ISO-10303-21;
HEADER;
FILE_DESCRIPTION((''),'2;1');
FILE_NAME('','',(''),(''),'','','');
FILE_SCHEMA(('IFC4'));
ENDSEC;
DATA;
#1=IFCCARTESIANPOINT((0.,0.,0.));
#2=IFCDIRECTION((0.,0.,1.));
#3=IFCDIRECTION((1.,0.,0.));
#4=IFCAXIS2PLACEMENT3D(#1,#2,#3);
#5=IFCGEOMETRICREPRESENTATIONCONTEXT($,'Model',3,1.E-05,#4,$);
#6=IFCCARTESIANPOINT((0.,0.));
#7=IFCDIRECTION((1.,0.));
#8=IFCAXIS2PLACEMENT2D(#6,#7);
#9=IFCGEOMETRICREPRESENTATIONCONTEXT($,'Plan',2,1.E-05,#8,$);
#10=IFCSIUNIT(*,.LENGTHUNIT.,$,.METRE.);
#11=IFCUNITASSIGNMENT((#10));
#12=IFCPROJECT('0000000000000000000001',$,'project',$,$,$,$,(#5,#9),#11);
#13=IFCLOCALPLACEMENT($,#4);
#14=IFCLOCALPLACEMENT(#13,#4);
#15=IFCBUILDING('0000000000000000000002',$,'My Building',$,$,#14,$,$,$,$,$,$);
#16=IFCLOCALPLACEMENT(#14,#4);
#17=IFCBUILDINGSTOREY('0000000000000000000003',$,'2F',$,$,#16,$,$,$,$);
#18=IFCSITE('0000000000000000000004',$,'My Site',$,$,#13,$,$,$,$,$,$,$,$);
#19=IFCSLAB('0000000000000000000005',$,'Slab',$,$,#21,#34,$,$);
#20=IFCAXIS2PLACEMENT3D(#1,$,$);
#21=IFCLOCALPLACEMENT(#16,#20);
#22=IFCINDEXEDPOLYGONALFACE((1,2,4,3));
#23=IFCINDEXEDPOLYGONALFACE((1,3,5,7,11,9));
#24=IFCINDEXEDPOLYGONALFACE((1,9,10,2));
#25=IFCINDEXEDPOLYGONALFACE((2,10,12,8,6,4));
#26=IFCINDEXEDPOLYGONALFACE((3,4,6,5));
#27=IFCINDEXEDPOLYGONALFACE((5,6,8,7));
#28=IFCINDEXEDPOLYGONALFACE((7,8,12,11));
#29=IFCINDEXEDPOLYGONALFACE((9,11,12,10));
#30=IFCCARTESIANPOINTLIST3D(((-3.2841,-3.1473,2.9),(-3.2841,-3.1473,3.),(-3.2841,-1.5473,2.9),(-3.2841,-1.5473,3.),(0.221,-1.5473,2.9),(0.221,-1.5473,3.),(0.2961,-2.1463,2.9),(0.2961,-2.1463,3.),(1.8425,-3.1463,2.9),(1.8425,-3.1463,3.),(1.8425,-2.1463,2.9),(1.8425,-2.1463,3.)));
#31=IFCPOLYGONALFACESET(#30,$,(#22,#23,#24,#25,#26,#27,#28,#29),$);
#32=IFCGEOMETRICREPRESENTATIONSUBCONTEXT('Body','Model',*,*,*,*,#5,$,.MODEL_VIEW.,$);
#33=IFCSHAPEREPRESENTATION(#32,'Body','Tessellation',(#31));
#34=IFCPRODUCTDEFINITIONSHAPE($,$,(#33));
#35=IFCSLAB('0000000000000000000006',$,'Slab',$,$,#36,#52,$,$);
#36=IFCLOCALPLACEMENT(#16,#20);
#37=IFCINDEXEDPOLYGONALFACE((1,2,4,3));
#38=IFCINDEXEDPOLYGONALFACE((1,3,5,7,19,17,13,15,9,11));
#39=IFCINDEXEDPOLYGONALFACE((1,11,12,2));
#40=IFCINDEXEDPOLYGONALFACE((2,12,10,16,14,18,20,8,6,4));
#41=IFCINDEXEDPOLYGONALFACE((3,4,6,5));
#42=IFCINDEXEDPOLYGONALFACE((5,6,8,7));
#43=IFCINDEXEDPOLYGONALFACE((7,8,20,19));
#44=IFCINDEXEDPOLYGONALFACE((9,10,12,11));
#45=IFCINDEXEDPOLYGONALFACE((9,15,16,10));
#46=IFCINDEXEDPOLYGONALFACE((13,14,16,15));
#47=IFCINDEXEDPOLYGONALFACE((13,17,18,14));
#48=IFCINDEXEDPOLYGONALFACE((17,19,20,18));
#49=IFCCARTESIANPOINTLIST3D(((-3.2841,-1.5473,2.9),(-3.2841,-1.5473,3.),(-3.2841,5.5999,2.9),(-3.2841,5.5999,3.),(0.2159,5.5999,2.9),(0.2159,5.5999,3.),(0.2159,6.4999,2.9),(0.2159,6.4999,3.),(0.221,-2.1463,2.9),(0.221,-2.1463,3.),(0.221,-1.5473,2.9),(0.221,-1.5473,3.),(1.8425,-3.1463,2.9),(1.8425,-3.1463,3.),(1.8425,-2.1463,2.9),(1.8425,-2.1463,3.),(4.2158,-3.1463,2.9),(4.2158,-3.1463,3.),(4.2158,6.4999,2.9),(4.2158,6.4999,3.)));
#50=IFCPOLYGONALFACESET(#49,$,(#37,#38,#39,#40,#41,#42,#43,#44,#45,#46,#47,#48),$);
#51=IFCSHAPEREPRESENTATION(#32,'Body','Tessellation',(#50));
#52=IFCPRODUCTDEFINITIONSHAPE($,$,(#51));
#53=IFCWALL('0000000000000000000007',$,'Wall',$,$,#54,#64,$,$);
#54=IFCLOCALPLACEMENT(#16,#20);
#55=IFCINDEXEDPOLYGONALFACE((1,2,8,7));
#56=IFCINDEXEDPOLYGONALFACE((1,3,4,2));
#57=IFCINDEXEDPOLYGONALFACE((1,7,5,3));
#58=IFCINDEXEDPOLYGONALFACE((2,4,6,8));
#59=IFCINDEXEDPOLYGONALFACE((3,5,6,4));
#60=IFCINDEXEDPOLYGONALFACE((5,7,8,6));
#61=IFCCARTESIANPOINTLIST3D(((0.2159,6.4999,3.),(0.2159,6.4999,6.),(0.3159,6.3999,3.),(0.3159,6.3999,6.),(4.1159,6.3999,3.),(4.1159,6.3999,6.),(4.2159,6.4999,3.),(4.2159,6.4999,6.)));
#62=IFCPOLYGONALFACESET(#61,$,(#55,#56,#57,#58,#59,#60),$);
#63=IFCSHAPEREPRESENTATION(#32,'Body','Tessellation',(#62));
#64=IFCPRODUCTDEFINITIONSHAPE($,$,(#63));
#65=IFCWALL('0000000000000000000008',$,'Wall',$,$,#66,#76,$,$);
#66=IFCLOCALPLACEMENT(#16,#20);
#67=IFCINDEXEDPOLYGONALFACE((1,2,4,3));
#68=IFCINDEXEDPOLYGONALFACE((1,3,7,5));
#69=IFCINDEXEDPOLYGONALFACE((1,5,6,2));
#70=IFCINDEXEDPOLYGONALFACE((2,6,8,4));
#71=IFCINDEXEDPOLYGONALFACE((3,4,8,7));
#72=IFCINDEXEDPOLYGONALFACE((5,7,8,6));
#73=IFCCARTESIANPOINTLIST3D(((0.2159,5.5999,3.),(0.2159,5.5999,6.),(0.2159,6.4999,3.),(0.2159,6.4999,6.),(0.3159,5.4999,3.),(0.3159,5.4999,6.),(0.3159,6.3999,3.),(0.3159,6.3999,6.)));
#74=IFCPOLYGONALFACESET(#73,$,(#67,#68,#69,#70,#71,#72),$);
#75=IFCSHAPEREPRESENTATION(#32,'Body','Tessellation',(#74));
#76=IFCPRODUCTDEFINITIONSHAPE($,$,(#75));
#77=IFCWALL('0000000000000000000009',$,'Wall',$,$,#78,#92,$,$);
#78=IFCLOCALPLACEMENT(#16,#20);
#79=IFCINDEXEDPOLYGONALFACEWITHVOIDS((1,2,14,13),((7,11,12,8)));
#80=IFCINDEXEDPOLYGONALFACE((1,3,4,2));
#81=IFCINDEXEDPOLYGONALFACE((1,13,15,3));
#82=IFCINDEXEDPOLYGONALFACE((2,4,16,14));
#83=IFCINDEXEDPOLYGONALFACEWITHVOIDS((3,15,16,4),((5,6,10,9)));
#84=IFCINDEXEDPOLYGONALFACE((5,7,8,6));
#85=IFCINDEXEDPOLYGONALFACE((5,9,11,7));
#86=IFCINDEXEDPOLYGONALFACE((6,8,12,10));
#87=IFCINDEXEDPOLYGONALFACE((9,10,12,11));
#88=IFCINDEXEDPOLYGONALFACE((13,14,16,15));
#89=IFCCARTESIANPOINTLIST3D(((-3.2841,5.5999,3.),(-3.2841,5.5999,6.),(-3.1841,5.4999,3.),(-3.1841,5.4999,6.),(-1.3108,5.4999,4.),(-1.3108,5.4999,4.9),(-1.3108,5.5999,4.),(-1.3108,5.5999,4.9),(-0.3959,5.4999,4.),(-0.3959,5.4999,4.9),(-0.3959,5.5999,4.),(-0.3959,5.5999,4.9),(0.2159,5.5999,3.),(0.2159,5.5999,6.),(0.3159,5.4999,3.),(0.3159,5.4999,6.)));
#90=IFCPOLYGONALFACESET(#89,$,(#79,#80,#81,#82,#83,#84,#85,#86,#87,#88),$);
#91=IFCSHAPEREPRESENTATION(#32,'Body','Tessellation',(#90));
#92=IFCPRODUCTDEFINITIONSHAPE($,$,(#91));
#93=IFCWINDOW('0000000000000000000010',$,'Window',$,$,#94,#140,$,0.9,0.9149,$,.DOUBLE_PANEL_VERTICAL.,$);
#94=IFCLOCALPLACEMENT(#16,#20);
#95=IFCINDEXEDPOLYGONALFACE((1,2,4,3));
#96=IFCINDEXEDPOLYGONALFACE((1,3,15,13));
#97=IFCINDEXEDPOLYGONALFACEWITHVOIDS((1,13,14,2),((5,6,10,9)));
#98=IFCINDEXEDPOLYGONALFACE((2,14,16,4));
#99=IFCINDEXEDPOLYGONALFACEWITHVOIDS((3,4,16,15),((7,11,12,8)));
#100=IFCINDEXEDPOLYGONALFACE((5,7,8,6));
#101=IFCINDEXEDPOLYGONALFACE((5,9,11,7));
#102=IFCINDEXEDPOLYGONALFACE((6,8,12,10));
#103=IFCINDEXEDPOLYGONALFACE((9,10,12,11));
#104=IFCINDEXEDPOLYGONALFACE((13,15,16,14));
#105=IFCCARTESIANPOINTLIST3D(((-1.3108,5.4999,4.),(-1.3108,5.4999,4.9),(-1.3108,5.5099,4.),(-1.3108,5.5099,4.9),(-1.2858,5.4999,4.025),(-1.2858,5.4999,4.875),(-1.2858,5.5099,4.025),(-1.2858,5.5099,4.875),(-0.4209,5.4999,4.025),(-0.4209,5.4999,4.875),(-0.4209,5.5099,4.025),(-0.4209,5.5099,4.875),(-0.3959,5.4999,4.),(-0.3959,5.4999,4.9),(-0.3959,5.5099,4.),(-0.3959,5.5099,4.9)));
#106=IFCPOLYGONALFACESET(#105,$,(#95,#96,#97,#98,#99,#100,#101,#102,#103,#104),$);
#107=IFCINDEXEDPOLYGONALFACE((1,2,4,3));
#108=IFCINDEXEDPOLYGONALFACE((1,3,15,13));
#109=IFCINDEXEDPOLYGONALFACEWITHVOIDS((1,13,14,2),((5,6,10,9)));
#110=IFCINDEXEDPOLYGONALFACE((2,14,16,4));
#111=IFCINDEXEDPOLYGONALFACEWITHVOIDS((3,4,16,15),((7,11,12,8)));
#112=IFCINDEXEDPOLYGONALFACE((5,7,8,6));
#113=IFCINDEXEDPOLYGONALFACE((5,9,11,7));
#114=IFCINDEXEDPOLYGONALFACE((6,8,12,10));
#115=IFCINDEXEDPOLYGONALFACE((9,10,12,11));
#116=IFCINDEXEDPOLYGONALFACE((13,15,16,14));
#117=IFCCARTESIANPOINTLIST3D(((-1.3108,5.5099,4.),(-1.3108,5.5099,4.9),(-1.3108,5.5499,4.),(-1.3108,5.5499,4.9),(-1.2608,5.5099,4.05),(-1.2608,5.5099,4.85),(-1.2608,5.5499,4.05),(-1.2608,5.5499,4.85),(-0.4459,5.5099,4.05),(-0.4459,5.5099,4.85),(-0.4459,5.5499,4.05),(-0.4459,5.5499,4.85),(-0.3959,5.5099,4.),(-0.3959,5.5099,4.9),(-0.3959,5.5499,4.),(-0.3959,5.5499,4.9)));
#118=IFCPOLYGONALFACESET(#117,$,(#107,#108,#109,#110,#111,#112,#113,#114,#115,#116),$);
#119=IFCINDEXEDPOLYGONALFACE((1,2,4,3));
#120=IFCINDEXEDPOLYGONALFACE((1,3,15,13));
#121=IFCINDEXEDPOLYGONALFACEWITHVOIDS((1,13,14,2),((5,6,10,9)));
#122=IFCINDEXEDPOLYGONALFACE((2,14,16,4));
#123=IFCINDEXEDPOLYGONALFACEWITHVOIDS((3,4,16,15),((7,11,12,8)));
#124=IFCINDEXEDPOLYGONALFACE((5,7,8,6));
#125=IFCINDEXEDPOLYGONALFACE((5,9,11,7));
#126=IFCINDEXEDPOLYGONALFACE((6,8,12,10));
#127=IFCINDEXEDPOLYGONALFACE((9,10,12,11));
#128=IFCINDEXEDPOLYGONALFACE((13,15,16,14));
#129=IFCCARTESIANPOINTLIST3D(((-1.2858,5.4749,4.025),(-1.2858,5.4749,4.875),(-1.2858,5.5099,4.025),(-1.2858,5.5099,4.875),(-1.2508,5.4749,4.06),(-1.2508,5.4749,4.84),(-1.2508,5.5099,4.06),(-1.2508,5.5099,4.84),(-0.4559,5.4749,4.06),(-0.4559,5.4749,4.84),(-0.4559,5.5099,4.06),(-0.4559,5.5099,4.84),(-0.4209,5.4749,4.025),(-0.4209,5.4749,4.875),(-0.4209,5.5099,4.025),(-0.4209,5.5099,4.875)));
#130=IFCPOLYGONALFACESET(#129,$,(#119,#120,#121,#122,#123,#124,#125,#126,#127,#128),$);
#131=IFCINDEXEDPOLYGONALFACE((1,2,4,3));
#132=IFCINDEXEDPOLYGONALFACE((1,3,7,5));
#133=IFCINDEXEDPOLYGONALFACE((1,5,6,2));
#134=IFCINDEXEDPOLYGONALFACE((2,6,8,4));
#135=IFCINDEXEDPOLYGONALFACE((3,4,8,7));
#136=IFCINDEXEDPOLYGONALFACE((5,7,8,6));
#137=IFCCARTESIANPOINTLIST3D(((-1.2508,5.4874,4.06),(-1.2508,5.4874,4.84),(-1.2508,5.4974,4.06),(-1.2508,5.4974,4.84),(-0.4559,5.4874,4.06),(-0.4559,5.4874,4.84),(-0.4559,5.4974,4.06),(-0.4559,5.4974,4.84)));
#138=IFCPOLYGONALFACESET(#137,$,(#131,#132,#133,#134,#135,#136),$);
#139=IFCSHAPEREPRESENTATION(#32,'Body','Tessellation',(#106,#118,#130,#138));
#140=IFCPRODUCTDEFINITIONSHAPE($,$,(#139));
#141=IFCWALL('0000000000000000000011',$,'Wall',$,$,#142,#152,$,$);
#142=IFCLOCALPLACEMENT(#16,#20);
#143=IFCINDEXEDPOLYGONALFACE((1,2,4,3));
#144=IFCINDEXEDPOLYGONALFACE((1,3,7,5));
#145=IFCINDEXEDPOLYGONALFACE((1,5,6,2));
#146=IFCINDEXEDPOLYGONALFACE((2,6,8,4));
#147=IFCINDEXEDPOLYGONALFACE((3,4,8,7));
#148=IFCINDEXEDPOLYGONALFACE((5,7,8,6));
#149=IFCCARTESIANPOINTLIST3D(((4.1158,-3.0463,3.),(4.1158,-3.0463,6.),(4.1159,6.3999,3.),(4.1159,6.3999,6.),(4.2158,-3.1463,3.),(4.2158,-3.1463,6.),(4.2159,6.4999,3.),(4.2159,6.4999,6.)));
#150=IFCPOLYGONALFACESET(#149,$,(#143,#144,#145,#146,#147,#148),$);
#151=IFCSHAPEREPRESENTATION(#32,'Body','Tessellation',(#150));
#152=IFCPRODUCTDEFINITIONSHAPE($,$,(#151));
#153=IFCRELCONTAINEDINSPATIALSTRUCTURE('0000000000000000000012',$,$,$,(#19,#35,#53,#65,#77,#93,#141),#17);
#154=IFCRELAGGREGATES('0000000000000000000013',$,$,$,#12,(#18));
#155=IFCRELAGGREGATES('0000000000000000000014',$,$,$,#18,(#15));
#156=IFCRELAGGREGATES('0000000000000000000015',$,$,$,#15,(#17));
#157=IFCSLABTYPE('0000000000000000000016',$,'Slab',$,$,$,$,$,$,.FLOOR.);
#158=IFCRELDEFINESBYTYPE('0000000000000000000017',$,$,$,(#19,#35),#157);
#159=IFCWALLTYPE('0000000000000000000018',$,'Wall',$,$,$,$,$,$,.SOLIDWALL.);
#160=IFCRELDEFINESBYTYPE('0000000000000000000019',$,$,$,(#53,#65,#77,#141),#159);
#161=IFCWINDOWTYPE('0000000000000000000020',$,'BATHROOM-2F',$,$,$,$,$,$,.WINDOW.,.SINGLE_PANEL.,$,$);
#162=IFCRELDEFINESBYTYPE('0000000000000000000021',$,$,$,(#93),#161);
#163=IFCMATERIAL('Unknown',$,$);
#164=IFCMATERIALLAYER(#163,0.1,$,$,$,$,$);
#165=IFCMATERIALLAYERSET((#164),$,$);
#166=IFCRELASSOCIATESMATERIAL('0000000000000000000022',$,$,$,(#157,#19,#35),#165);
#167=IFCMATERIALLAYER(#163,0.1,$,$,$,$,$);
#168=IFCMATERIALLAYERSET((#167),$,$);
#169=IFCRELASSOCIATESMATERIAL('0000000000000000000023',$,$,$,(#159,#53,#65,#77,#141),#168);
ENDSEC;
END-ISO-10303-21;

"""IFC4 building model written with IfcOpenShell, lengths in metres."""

from ifc_helpers import new_model, entity, si_unit, frame, origin_with_axes, origin_2d_with_axis, place, context, subcontext, project, spatial, line, indexed_curve, outline, extrude, shape, source, transform, mapped, material, layer, layer_set, layer_usage, type_object, type_shapes, element, fill, save


model = new_model("IFC4")

# Units and contexts
model_context = context("Model", 3, precision=1e-05, world=origin_with_axes())
plan_context = context("Plan", 2, precision=1e-05, world=origin_2d_with_axis())
body_context_1 = subcontext(model_context, "Body", "Model", "MODEL_VIEW")
body_context_2 = subcontext(plan_context, "Body", "Plan", "PLAN_VIEW")
ifc_project = project(units=[si_unit("LENGTHUNIT", "METRE")], contexts=[model_context, plan_context])

# Site, building, storey
site_placement = place(None, origin_with_axes())
site = spatial("IfcSite", under=ifc_project, at=site_placement, Name="My Site")
building_placement = place(site_placement, origin_with_axes())
building = spatial("IfcBuilding", under=site, at=building_placement, Name="My Building")
storey_placement = place(building_placement, origin_with_axes())
storey = spatial("IfcBuildingStorey", under=building, at=storey_placement, Name="2F")

# Slabs
ifc_material_1 = material(Name="Unknown")
ifc_layer_1 = layer(ifc_material_1, 0.1)
ifc_layer_set_1 = layer_set([ifc_layer_1])
ifc_layer_usage_1 = layer_usage(ifc_layer_set_1, "AXIS3", "POSITIVE", -0.1)
slab_type = type_object("IfcSlabType", Name="Slab", PredefinedType="FLOOR", material=ifc_layer_set_1)
slab_1_placement = place(storey_placement, frame((-3.2841, -1.5473, 3.0), z_axis=(0.0, 0.0, 1.0), x_axis=(1.0, 0.0, 0.0)))
element("IfcSlab", 1, at=slab_1_placement, inside=storey, type_object=slab_type, material=ifc_layer_usage_1, Name="Slab", context=body_context_1, shape_type="SweptSolid", body=[
    extrude(outline(indexed_curve([(0.0, 0.0), (0.0, -1.6), (5.1266, -1.599), (5.1266, -0.599), (3.5803, -0.599), (3.5052, 0.0), (0.0, 0.0)])), frame((0.0, 0.0, -0.1), z_axis=(0.0, 0.0, 1.0), x_axis=(1.0, 0.0, 0.0)), (0.0, 0.0, 1.0), 0.1),
])
ifc_layer_usage_2 = layer_usage(ifc_layer_set_1, "AXIS3", "POSITIVE", -0.1)
slab_2_placement = place(storey_placement, frame((4.2158, 6.4999, 3.0), z_axis=(0.0, 0.0, 1.0), x_axis=(1.0, 0.0, 0.0)))
element("IfcSlab", 2, at=slab_2_placement, inside=storey, type_object=slab_type, material=ifc_layer_usage_2, Name="Slab", context=body_context_1, shape_type="SweptSolid", body=[
    extrude(outline(indexed_curve([(0.0, 0.0), (-4.0, 0.0), (-4.0, -0.9), (-7.5, -0.9), (-7.5, -8.0471), (-3.9948, -8.0471), (-3.9948, -8.6461), (-2.3734, -8.6461), (-2.3734, -9.6461), (0.0, -9.6461), (0.0, 0.0)])), frame((0.0, 0.0, -0.1), z_axis=(0.0, 0.0, 1.0), x_axis=(1.0, 0.0, 0.0)), (0.0, 0.0, 1.0), 0.1),
])

# Walls
ifc_layer_2 = layer(ifc_material_1, 0.1)
ifc_layer_set_2 = layer_set([ifc_layer_2])
ifc_layer_usage_3 = layer_usage(ifc_layer_set_2, "AXIS2", "POSITIVE", 0.0)
wall_type = type_object("IfcWallType", Name="Wall", PredefinedType="SOLIDWALL", material=ifc_layer_set_2)
wall_1_placement = place(storey_placement, frame((4.2159, 6.4999, 3.0), z_axis=(0.0, 0.0, 1.0), x_axis=(-1.0, 0.0, 0.0)))
element("IfcWall", 3, at=wall_1_placement, inside=storey, type_object=wall_type, material=ifc_layer_usage_3, Name="Wall", context=body_context_1, shape_type="SweptSolid", body=[
    extrude(outline(indexed_curve([(0.0, 0.0), (0.1, 0.1), (3.9, 0.1), (4.0, 0.0)], segments=[line(1, 2, 3, 4, 1)])), origin_with_axes(), (0.0, 0.0, 1.0), 3.0),
])
ifc_layer_usage_4 = layer_usage(ifc_layer_set_2, "AXIS2", "POSITIVE", 0.0)
wall_2_placement = place(storey_placement, frame((0.2159, 6.4999, 3.0), z_axis=(0.0, 0.0, 1.0), x_axis=(0.0, -1.0, 0.0)))
element("IfcWall", 4, at=wall_2_placement, inside=storey, type_object=wall_type, material=ifc_layer_usage_4, Name="Wall", context=body_context_1, shape_type="SweptSolid", body=[
    extrude(outline(indexed_curve([(0.0, 0.0), (0.1, 0.1), (1.0, 0.1), (0.9, 0.0)], segments=[line(1, 2, 3, 4, 1)])), origin_with_axes(), (0.0, 0.0, 1.0), 3.0),
])

# Wall, opening, window
ifc_layer_usage_5 = layer_usage(ifc_layer_set_2, "AXIS2", "POSITIVE", 0.0)
wall_3_placement = place(storey_placement, frame((0.2159, 5.5999, 3.0), z_axis=(0.0, 0.0, 1.0), x_axis=(-1.0, 0.0, 0.0)))
wall_3 = element("IfcWall", 5, at=wall_3_placement, inside=storey, type_object=wall_type, material=ifc_layer_usage_5, Name="Wall", context=body_context_1, shape_type="SweptSolid", body=[
    extrude(outline(indexed_curve([(0.0, 0.0), (-0.1, 0.1), (3.4, 0.1), (3.5, 0.0)], segments=[line(1, 2, 3, 4, 1)])), origin_with_axes(), (0.0, 0.0, 1.0), 3.0),
])
shared_shape_1 = source(origin_with_axes(), body_context_1, "Body", "SweptSolid", [
    extrude(outline(indexed_curve([(0.0, 0.0), (0.9149, 0.0), (0.9149, 0.9), (0.0, 0.9)], segments=[line(1, 2, 3, 4, 1)])), frame((0.0, -0.6, 0.0), z_axis=(0.0, -1.0, 0.0), x_axis=(1.0, 0.0, 0.0)), (0.0, 0.0, -1.0), 1.2),
])
opening_1_placement = place(wall_3_placement, frame((0.6117, 0.0, 1.0), z_axis=(0.0, 0.0, 1.0), x_axis=(1.0, -0.000001, 0.0)))
opening_1 = element("IfcOpeningElement", 6, at=opening_1_placement, cuts=wall_3, PredefinedType="OPENING", context=body_context_1, shape_type="MappedRepresentation", body=[
    mapped(shared_shape_1, transform((0.0, 0.0, 0.0), x_axis=(1.0, 0.0, 0.0), y_axis=(0.0, 1.0, 0.0), z_axis=(0.0, 0.0, 1.0), scale=1.0)),
])
window_type_1 = type_object("IfcWindowType", Name="BATHROOM-2F", PartitioningType="SINGLE_PANEL", PredefinedType="WINDOW")
shared_shape_2 = source(origin_with_axes(), body_context_1, "Body", "SweptSolid", [
    extrude(outline(indexed_curve([(0.0, 0.0), (0.9149, 0.0), (0.9149, 0.9), (0.0, 0.9)], segments=[line(1, 2, 3, 4, 1)]), holes=[indexed_curve([(0.025, 0.025), (0.8899, 0.025), (0.8899, 0.875), (0.025, 0.875)], segments=[line(1, 2, 3, 4, 1)])]), frame((0.0, 0.09, 0.0), z_axis=(0.0, -1.0, 0.0), x_axis=(1.0, 0.0, 0.0)), (0.0, 0.0, -1.0), 0.01),
    extrude(outline(indexed_curve([(0.0, 0.0), (0.9149, 0.0), (0.9149, 0.9), (0.0, 0.9)], segments=[line(1, 2, 3, 4, 1)]), holes=[indexed_curve([(0.05, 0.05), (0.8649, 0.05), (0.8649, 0.85), (0.05, 0.85)], segments=[line(1, 2, 3, 4, 1)])]), frame((0.0, 0.05, 0.0), z_axis=(0.0, -1.0, 0.0), x_axis=(1.0, 0.0, 0.0)), (0.0, 0.0, -1.0), 0.04),
    extrude(outline(indexed_curve([(0.0, 0.0), (0.8649, 0.0), (0.8649, 0.85), (0.0, 0.85)], segments=[line(1, 2, 3, 4, 1)]), holes=[indexed_curve([(0.035, 0.035), (0.8299, 0.035), (0.8299, 0.815), (0.035, 0.815)], segments=[line(1, 2, 3, 4, 1)])]), frame((0.025, 0.09, 0.025), z_axis=(0.0, -1.0, 0.0), x_axis=(1.0, 0.0, 0.0)), (0.0, 0.0, -1.0), 0.035),
    extrude(outline(indexed_curve([(0.035, 0.035), (0.8299, 0.035), (0.8299, 0.815), (0.035, 0.815)], segments=[line(1, 2, 3, 4, 1)])), frame((0.025, 0.1025, 0.025), z_axis=(0.0, -1.0, 0.0), x_axis=(1.0, 0.0, 0.0)), (0.0, 0.0, -1.0), 0.01),
])
shared_shape_3 = source(origin_with_axes(), body_context_2, "Body", "Curve2D", [
    entity("IfcIndexedPolyCurve", entity("IfcCartesianPointList2D", [[0.05, 0.05], [0.8649, 0.05]])),
    entity("IfcIndexedPolyCurve", entity("IfcCartesianPointList2D", [[0.0, 0.1], [0.025, 0.1], [0.025, 0.09], [0.05, 0.09], [0.05, 0.05], [0.0, 0.05]]), [entity("IfcLineIndex", [1, 2, 3, 4, 5, 6, 1])]),
    entity("IfcIndexedPolyCurve", entity("IfcCartesianPointList2D", [[0.9149, 0.1], [0.8899, 0.1], [0.8899, 0.09], [0.8649, 0.09], [0.8649, 0.05], [0.9149, 0.05]]), [entity("IfcLineIndex", [1, 2, 3, 4, 5, 6, 1])]),
    entity("IfcIndexedPolyCurve", entity("IfcCartesianPointList2D", [[0.025, 0.09], [0.06, 0.09], [0.06, 0.125], [0.025, 0.125]]), [entity("IfcLineIndex", [1, 2, 3, 4, 1])]),
    entity("IfcIndexedPolyCurve", entity("IfcCartesianPointList2D", [[0.8899, 0.09], [0.8549, 0.09], [0.8549, 0.125], [0.8899, 0.125]]), [entity("IfcLineIndex", [1, 2, 3, 4, 1])]),
    entity("IfcIndexedPolyCurve", entity("IfcCartesianPointList2D", [[0.06, 0.09], [0.8549, 0.09]])),
    entity("IfcIndexedPolyCurve", entity("IfcCartesianPointList2D", [[0.06, 0.125], [0.8549, 0.125]])),
    entity("IfcIndexedPolyCurve", entity("IfcCartesianPointList2D", [[0.06, 0.1075], [0.8549, 0.1075]])),
])
type_shapes(window_type_1, [shared_shape_2, shared_shape_3])
window_1_placement = place(opening_1_placement, frame((0.0, 0.0, 0.0), z_axis=(0.0, 0.0, 1.0), x_axis=(1.0, 0.0, 0.0)))
window_1 = element("IfcWindow", 7, at=window_1_placement, inside=storey, type_object=window_type_1, Name="Window", OverallHeight=0.9, OverallWidth=0.9149, PartitioningType="DOUBLE_PANEL_VERTICAL", shapes=[
    shape(body_context_1, "Body", "MappedRepresentation", [mapped(shared_shape_2, transform((0.0, 0.0, 0.0), x_axis=(1.0, 0.0, 0.0), y_axis=(0.0, 1.0, 0.0), z_axis=(0.0, 0.0, 1.0), scale=1.0))]),
    shape(body_context_2, "Body", "MappedRepresentation", [mapped(shared_shape_3, transform((0.0, 0.0, 0.0), x_axis=(1.0, 0.0, 0.0), y_axis=(0.0, 1.0, 0.0), z_axis=(0.0, 0.0, 1.0), scale=1.0))]),
])
fill(opening_1, window_1)

# Wall
ifc_layer_usage_6 = layer_usage(ifc_layer_set_2, "AXIS2", "POSITIVE", 0.0)
wall_4_placement = place(storey_placement, frame((4.2158, -3.1463, 3.0), z_axis=(0.0, 0.0, 1.0), x_axis=(0.0, 1.0, 0.0)))
element("IfcWall", 8, at=wall_4_placement, inside=storey, type_object=wall_type, material=ifc_layer_usage_6, Name="Wall", context=body_context_1, shape_type="SweptSolid", body=[
    extrude(outline(indexed_curve([(0.0, 0.0), (0.1, 0.1), (9.5461, 0.1), (9.6461, 0.0)], segments=[line(1, 2, 3, 4, 1)])), origin_with_axes(), (0.0, 0.0, 1.0), 3.0),
])

save(model, "model.ifc")
